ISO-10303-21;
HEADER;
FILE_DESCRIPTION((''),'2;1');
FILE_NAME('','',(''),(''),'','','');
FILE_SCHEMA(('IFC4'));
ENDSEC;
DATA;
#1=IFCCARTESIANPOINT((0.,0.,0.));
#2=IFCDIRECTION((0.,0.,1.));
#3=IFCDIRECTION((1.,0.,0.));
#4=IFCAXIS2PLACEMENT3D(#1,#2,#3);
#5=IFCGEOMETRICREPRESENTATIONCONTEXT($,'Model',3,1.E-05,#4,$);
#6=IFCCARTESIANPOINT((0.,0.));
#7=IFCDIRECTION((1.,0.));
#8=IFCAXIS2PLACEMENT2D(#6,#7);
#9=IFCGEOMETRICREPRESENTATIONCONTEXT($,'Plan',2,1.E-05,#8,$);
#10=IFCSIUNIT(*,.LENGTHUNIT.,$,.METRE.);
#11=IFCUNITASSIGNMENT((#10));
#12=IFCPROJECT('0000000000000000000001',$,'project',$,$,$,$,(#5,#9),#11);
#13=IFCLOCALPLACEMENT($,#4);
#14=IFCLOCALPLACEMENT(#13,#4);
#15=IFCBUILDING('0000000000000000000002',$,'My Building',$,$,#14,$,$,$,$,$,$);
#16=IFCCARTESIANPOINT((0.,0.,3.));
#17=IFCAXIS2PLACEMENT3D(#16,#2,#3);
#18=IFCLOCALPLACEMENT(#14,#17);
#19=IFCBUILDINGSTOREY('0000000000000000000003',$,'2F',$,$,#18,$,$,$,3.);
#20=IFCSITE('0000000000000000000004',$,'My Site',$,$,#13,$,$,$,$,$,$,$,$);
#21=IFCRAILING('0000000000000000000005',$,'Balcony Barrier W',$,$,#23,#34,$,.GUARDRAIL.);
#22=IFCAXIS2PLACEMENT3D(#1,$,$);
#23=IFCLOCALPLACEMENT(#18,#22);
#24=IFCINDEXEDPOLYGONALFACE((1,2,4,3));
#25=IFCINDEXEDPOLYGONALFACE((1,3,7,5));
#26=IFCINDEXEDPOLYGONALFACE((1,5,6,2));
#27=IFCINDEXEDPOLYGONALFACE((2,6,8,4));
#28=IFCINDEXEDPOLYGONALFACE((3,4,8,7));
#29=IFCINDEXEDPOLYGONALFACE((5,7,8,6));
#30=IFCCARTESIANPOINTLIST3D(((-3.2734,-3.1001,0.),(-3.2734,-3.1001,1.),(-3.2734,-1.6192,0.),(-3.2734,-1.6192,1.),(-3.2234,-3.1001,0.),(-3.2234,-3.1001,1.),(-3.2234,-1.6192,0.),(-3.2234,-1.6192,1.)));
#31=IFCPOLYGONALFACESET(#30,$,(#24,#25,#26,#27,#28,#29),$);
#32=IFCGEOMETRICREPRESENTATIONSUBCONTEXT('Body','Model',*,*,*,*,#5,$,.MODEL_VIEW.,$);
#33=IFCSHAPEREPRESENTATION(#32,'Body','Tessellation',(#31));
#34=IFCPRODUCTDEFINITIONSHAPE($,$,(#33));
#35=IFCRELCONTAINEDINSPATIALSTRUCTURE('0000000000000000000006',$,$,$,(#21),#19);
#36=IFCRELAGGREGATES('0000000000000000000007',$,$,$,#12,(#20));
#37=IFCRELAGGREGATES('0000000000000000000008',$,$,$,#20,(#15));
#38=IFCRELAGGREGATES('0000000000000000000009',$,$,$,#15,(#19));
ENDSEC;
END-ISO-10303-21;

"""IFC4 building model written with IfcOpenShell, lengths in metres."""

from ifc_helpers import new_model, si_unit, frame, origin_with_axes, origin_2d_with_axis, place, context, subcontext, project, spatial, polyline, outline, extrude, element, save


model = new_model("IFC4")

# Units and contexts
model_context = context("Model", 3, precision=1e-05, world=origin_with_axes())
plan_context = context("Plan", 2, precision=1e-05, world=origin_2d_with_axis())
body_context_1 = subcontext(model_context, "Body", "Model", "MODEL_VIEW")
ifc_project = project(units=[si_unit("LENGTHUNIT", "METRE")], contexts=[model_context, plan_context])

# Site, building, storey
site_placement = place(None, origin_with_axes())
site = spatial("IfcSite", under=ifc_project, at=site_placement, Name="My Site")
building_placement = place(site_placement, origin_with_axes())
building = spatial("IfcBuilding", under=site, at=building_placement, Name="My Building")
storey_placement = place(building_placement, frame((0.0, 0.0, 3.0), z_axis=(0.0, 0.0, 1.0), x_axis=(1.0, 0.0, 0.0)))
storey = spatial("IfcBuildingStorey", under=building, at=storey_placement, Name="2F", Elevation=3.0)

# Railing
railing_1_placement = place(storey_placement, frame((-3.2734, -3.1001, 0.0), z_axis=(1.0, 0.0, 0.0), x_axis=(0.0, 1.0, 0.0)))
element("IfcRailing", 1, at=railing_1_placement, inside=storey, Name="Balcony Barrier W", PredefinedType="GUARDRAIL", context=body_context_1, shape_type="SweptSolid", body=[
    extrude(outline(polyline([(0.0, 0.0), (1.4809, 0.0), (1.4809, 1.0), (0.0, 1.0), (0.0, 0.0)])), origin_with_axes(), (0.0, 0.0, 1.0), 0.05),
])

save(model, "model.ifc")
